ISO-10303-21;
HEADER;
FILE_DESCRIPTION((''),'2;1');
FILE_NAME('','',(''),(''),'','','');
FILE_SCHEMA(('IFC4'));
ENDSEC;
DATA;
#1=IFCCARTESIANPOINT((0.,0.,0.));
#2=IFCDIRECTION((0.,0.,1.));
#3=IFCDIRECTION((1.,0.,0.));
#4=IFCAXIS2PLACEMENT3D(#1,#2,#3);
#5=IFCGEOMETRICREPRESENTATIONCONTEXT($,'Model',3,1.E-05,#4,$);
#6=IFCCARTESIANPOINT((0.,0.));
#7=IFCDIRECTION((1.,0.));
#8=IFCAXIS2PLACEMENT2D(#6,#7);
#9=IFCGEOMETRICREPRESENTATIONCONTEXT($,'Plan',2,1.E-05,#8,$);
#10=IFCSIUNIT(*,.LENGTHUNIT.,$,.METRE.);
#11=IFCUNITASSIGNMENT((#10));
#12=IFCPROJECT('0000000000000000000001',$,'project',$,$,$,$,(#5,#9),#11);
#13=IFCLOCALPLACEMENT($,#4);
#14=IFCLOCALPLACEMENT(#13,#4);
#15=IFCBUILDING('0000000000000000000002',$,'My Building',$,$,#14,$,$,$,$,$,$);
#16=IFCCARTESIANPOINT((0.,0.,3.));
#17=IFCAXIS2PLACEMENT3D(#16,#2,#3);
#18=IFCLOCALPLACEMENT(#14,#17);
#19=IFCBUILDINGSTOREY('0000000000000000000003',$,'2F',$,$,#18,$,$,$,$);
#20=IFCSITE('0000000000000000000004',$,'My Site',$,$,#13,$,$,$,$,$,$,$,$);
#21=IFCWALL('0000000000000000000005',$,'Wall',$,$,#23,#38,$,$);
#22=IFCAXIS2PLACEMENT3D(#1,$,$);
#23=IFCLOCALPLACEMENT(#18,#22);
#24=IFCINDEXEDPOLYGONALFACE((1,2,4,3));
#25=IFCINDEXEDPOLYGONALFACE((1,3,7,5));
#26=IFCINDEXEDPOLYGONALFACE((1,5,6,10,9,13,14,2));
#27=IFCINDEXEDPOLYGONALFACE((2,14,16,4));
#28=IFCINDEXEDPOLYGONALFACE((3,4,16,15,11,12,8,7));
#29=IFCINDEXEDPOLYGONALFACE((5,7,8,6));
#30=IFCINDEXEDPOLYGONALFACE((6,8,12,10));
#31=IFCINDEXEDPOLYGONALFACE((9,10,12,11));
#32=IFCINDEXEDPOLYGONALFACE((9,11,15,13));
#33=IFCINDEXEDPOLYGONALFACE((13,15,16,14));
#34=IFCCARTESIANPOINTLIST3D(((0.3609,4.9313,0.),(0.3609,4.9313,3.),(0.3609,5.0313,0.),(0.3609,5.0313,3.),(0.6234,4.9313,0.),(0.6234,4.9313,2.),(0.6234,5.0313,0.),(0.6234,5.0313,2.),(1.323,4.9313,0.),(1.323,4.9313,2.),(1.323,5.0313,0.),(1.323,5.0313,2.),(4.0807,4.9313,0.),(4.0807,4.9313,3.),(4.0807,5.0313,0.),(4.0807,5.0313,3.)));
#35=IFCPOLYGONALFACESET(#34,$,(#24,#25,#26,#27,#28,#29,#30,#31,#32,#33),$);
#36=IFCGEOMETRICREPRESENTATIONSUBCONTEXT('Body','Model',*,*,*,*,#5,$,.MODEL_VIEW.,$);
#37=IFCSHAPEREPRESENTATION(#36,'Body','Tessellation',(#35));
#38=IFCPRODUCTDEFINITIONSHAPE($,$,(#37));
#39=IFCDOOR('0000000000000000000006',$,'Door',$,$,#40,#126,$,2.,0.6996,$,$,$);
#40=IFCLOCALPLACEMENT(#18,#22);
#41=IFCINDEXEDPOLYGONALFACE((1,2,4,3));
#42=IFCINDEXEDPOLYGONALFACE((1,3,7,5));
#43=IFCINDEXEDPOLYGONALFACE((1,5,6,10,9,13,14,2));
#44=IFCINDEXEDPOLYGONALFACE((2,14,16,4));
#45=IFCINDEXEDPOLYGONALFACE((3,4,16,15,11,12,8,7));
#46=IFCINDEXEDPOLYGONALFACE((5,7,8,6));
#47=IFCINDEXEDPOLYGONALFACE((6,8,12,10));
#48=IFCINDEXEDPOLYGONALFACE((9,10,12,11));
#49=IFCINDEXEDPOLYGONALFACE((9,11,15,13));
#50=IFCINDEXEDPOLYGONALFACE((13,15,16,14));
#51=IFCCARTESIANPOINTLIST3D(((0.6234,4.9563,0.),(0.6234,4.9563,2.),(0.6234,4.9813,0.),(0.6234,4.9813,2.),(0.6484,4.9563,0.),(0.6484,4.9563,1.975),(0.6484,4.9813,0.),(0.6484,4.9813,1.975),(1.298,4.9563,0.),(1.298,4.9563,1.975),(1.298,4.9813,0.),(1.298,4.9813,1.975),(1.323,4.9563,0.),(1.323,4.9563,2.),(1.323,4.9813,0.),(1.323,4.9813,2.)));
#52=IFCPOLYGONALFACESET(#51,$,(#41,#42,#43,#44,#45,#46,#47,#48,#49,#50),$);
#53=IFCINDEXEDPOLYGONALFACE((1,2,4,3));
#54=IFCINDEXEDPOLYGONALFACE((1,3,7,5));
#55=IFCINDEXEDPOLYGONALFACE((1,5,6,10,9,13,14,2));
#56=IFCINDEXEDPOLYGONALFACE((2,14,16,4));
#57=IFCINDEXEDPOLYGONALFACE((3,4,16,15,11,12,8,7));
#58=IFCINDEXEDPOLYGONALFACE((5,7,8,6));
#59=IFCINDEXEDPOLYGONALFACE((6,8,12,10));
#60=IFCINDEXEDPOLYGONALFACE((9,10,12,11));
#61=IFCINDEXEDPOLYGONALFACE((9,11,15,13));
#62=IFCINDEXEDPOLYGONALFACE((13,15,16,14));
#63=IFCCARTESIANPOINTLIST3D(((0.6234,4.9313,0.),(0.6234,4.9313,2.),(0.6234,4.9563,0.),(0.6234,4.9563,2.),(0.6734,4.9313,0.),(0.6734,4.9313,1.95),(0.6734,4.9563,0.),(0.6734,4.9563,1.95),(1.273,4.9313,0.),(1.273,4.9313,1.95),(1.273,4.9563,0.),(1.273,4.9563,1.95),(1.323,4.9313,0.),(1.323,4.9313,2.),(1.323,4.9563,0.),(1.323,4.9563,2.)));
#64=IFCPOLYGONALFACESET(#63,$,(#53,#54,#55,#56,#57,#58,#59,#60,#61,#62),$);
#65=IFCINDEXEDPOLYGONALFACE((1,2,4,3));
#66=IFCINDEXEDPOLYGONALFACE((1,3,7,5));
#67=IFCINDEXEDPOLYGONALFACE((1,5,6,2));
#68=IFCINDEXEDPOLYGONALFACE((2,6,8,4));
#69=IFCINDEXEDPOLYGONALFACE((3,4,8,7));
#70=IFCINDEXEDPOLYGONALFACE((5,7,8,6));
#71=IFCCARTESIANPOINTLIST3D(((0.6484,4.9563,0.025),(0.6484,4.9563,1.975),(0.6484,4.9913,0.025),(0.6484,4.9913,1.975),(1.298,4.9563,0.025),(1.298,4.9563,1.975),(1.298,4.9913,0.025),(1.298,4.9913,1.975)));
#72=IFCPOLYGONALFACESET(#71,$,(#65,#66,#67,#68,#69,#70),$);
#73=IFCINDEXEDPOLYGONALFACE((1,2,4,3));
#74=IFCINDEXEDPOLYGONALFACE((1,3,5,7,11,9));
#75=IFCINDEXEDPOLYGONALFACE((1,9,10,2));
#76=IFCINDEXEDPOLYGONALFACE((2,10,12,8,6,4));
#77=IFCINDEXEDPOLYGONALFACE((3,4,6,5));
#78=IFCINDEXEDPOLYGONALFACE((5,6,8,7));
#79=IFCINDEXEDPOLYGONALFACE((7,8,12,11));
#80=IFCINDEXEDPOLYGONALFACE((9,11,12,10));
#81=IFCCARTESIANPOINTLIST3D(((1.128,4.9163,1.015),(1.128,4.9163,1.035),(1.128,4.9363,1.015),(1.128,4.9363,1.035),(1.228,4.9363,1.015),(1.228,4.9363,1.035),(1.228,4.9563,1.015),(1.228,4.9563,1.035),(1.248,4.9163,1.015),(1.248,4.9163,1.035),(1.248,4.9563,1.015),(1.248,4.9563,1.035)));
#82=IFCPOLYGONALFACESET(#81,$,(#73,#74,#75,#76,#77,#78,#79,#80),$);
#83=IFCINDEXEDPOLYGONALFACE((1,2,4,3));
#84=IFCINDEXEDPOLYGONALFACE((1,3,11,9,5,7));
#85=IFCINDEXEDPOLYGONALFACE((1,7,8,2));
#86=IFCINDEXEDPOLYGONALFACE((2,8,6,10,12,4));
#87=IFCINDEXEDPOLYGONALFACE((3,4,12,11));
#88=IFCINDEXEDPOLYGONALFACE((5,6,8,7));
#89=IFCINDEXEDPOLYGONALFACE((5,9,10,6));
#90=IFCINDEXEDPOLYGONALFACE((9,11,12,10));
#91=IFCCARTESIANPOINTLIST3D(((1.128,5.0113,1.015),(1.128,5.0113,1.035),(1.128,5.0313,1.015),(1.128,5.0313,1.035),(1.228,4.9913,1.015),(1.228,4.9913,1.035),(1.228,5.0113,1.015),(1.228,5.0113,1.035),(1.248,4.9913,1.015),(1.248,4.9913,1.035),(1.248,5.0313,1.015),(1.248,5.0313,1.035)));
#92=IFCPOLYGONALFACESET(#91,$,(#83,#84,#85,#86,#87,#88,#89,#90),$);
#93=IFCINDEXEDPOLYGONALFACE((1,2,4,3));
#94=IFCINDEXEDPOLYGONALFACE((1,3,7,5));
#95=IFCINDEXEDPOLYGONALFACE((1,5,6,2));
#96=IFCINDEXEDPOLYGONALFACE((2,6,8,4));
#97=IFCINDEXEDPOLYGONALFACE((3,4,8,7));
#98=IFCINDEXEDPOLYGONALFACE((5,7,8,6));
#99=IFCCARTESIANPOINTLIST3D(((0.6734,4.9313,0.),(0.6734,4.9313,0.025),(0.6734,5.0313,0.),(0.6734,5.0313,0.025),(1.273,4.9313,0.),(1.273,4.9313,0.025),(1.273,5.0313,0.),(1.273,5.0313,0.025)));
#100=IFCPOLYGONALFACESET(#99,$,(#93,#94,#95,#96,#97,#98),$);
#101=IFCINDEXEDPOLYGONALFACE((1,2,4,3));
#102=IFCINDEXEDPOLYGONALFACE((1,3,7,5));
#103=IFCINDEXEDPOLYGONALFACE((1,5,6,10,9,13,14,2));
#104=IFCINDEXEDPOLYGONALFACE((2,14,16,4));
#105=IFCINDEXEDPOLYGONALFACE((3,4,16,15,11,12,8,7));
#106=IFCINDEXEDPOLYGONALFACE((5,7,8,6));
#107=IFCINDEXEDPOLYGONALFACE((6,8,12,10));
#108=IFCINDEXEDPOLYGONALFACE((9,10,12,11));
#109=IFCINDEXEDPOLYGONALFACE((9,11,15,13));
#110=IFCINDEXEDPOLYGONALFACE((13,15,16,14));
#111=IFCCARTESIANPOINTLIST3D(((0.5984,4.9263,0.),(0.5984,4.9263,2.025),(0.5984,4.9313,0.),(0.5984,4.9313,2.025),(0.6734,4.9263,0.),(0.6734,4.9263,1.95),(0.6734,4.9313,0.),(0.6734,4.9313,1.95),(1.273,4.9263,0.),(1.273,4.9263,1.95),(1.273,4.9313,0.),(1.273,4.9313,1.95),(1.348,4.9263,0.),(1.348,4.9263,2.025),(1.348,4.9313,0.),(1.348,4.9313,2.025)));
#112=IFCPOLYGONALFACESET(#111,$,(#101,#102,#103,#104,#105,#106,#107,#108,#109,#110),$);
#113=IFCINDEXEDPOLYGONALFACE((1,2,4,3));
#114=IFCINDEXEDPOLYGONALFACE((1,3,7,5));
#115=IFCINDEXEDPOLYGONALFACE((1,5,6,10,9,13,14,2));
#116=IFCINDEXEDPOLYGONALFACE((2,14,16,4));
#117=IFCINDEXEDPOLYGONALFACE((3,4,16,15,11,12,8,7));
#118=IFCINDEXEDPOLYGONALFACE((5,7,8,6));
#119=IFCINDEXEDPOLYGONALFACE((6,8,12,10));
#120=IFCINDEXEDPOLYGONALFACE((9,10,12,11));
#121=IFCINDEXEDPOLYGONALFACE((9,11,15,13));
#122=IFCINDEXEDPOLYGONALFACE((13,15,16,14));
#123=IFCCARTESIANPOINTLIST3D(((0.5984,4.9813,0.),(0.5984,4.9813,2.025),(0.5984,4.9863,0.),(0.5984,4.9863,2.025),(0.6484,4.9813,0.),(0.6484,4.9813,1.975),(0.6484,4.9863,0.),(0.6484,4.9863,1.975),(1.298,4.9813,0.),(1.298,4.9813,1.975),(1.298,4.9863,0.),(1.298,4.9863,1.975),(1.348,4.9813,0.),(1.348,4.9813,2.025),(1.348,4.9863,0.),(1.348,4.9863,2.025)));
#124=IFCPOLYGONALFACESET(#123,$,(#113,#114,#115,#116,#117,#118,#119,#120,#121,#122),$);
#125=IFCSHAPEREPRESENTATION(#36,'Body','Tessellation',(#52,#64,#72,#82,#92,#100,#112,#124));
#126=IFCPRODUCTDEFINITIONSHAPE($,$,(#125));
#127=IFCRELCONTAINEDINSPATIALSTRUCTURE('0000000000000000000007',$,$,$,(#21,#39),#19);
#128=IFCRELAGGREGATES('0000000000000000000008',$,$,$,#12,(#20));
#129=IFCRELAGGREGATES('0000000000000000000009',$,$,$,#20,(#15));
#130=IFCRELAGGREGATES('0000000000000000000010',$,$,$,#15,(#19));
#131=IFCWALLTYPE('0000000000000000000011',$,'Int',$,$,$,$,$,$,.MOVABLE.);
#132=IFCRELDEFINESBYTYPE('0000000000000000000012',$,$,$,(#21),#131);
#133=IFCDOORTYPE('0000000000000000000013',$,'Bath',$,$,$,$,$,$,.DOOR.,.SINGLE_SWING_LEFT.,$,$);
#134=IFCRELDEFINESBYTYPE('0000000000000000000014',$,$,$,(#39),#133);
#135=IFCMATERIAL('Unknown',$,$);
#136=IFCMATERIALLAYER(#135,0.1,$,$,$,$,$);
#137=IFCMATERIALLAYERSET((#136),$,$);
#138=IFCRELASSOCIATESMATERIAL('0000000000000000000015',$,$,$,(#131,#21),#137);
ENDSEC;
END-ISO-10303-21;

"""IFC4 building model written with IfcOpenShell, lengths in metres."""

from ifc_helpers import new_model, entity, si_unit, frame, origin_with_axes, origin_2d_with_axis, place, context, subcontext, project, spatial, line, indexed_curve, outline, extrude, shape, source, transform, mapped, material, layer, layer_set, layer_usage, type_object, type_shapes, element, fill, save


model = new_model("IFC4")

# Units and contexts
model_context = context("Model", 3, precision=1e-05, world=origin_with_axes())
plan_context = context("Plan", 2, precision=1e-05, world=origin_2d_with_axis())
body_context_1 = subcontext(model_context, "Body", "Model", "MODEL_VIEW")
body_context_2 = subcontext(plan_context, "Body", "Plan", "PLAN_VIEW")
ifc_project = project(units=[si_unit("LENGTHUNIT", "METRE")], contexts=[model_context, plan_context])

# Site, building, storey
site_placement = place(None, origin_with_axes())
site = spatial("IfcSite", under=ifc_project, at=site_placement, Name="My Site")
building_placement = place(site_placement, origin_with_axes())
building = spatial("IfcBuilding", under=site, at=building_placement, Name="My Building")
storey_placement = place(building_placement, frame((0.0, 0.0, 3.0), z_axis=(0.0, 0.0, 1.0), x_axis=(1.0, 0.0, 0.0)))
storey = spatial("IfcBuildingStorey", under=building, at=storey_placement, Name="2F")

# Shared definitions
ifc_material = material(Name="Unknown")

# Shared definitions
ifc_layer_1 = layer(ifc_material, 0.1)
ifc_layer_set_1 = layer_set([ifc_layer_1])
wall_type_1 = type_object("IfcWallType", Name="Int", PredefinedType="MOVABLE", material=ifc_layer_set_1)

# Wall, opening, door
ifc_layer_usage_1 = layer_usage(ifc_layer_set_1, "AXIS2", "POSITIVE", 0.0)
wall_1_placement = place(storey_placement, frame((4.0807, 5.0313, 0.0), z_axis=(0.0, 0.0, 1.0), x_axis=(-1.0, 0.0, 0.0)))
wall_1 = element("IfcWall", 1, at=wall_1_placement, inside=storey, type_object=wall_type_1, material=ifc_layer_usage_1, Name="Wall", context=body_context_1, shape_type="SweptSolid", body=[
    extrude(outline(indexed_curve([(0.0, 0.0), (0.0, 0.1), (3.7198, 0.1), (3.7198, 0.0)], segments=[line(1, 2, 3, 4, 1)])), origin_with_axes(), (0.0, 0.0, 1.0), 3.0),
])
shared_shape_1 = source(origin_with_axes(), body_context_1, "Body", "SweptSolid", [
    extrude(outline(indexed_curve([(0.0, 0.0), (0.6996, 0.0), (0.6996, 2.0), (0.0, 2.0)], segments=[line(1, 2, 3, 4, 1)])), frame((0.0, -0.6, 0.0), z_axis=(0.0, -1.0, 0.0), x_axis=(1.0, 0.0, 0.0)), (0.0, 0.0, -1.0), 1.2),
])
opening_1_placement = place(wall_1_placement, frame((3.4573, 0.1, 0.0), z_axis=(0.0, 0.0, 1.0), x_axis=(-1.0, 0.0, 0.0)))
opening_1 = element("IfcOpeningElement", 2, at=opening_1_placement, cuts=wall_1, PredefinedType="OPENING", context=body_context_1, shape_type="MappedRepresentation", body=[
    mapped(shared_shape_1, transform((0.0, 0.0, 0.0), x_axis=(1.0, 0.0, 0.0), y_axis=(0.0, 1.0, 0.0), z_axis=(0.0, 0.0, 1.0), scale=1.0)),
])
door_type_1 = type_object("IfcDoorType", Name="Bath", OperationType="SINGLE_SWING_LEFT", PredefinedType="DOOR")
shared_shape_2 = source(origin_with_axes(), body_context_1, "Body", "SweptSolid", [
    extrude(outline(indexed_curve([(0.0, 0.0), (0.0, 2.0), (0.6996, 2.0), (0.6996, 0.0), (0.6746, 0.0), (0.6746, 1.975), (0.025, 1.975), (0.025, 0.0)], segments=[line(1, 2, 3, 4, 5, 6, 7, 8, 1)])), frame((0.0, 0.025, 0.0), z_axis=(0.0, -1.0, 0.0), x_axis=(1.0, 0.0, 0.0)), (0.0, 0.0, -1.0), 0.025),
    extrude(outline(indexed_curve([(0.0, 0.0), (0.0, 2.0), (0.6996, 2.0), (0.6996, 0.0), (0.6496, 0.0), (0.6496, 1.95), (0.05, 1.95), (0.05, 0.0)], segments=[line(1, 2, 3, 4, 5, 6, 7, 8, 1)])), frame((0.0, 0.0, 0.0), z_axis=(0.0, -1.0, 0.0), x_axis=(1.0, 0.0, 0.0)), (0.0, 0.0, -1.0), 0.025),
    extrude(outline(indexed_curve([(0.0, 0.0), (0.6496, 0.0), (0.6496, 0.035), (0.0, 0.035)], segments=[line(1, 2, 3, 4, 1)])), frame((0.025, 0.025, 0.025), z_axis=(0.0, 0.0, 1.0), x_axis=(1.0, 0.0, 0.0)), (0.0, 0.0, 1.0), 1.95),
    extrude(outline(indexed_curve([(0.0, 0.0), (0.0, -0.04), (-0.12, -0.04), (-0.12, -0.02), (-0.02, -0.02), (-0.02, 0.0)], segments=[line(1, 2, 3, 4, 5, 6, 1)])), frame((0.6246, 0.025, 1.015), z_axis=(0.0, 0.0, 1.0), x_axis=(1.0, 0.0, 0.0)), (0.0, 0.0, 1.0), 0.02),
    extrude(outline(indexed_curve([(0.0, 0.0), (0.0, 0.04), (-0.12, 0.04), (-0.12, 0.02), (-0.02, 0.02), (-0.02, 0.0)], segments=[line(1, 2, 3, 4, 5, 6, 1)])), frame((0.6246, 0.06, 1.015), z_axis=(0.0, 0.0, 1.0), x_axis=(1.0, 0.0, 0.0)), (0.0, 0.0, 1.0), 0.02),
    extrude(outline(indexed_curve([(0.0, 0.0), (0.5996, 0.0), (0.5996, 0.1), (0.0, 0.1)], segments=[line(1, 2, 3, 4, 1)])), frame((0.05, 0.0, 0.0), z_axis=(0.0, 0.0, 1.0), x_axis=(1.0, 0.0, 0.0)), (0.0, 0.0, 1.0), 0.025),
    extrude(outline(indexed_curve([(0.0, 0.0), (0.0, 2.025), (0.7496, 2.025), (0.7496, 0.0), (0.6746, 0.0), (0.6746, 1.95), (0.075, 1.95), (0.075, 0.0)], segments=[line(1, 2, 3, 4, 5, 6, 7, 8, 1)])), frame((-0.025, -0.005, 0.0), z_axis=(0.0, -1.0, 0.0), x_axis=(1.0, 0.0, 0.0)), (0.0, 0.0, -1.0), 0.005),
    extrude(outline(indexed_curve([(0.0, 0.0), (0.0, 2.025), (0.7496, 2.025), (0.7496, 0.0), (0.6996, 0.0), (0.6996, 1.975), (0.05, 1.975), (0.05, 0.0)], segments=[line(1, 2, 3, 4, 5, 6, 7, 8, 1)])), frame((-0.025, 0.05, 0.0), z_axis=(0.0, -1.0, 0.0), x_axis=(1.0, 0.0, 0.0)), (0.0, 0.0, -1.0), 0.005),
])
shared_shape_3 = source(origin_with_axes(), body_context_2, "Body", "Curve2D", [
    entity("IfcIndexedPolyCurve", entity("IfcCartesianPointList2D", [[0.0, 0.0], [0.0, 0.05], [0.025, 0.05], [0.025, 0.025], [0.05, 0.025], [0.05, 0.0]]), [entity("IfcLineIndex", [1, 2, 3, 4, 5, 6, 1])]),
    entity("IfcIndexedPolyCurve", entity("IfcCartesianPointList2D", [[0.6996, 0.0], [0.6996, 0.05], [0.6746, 0.05], [0.6746, 0.025], [0.6496, 0.025], [0.6496, 0.0]]), [entity("IfcLineIndex", [1, 2, 3, 4, 5, 6, 1])]),
    entity("IfcTrimmedCurve", entity("IfcEllipse", entity("IfcAxis2Placement2D", entity("IfcCartesianPoint", [0.06, 0.05]), entity("IfcDirection", [1.0, 0.0])), 0.6146, 0.6496), [entity("IfcCartesianPoint", [0.6746, 0.05])], [entity("IfcCartesianPoint", [0.06, 0.6996])], True, "CARTESIAN"),
    entity("IfcIndexedPolyCurve", entity("IfcCartesianPointList2D", [[0.025, 0.05], [0.06, 0.05], [0.06, 0.6996], [0.025, 0.6996]]), [entity("IfcLineIndex", [1, 2, 3, 4, 1])]),
])
type_shapes(door_type_1, [shared_shape_2, shared_shape_3])
door_1_placement = place(opening_1_placement, frame((0.0, 0.0, 0.0), z_axis=(0.0, 0.0, 1.0), x_axis=(1.0, 0.0, 0.0)))
door_1 = element("IfcDoor", 3, at=door_1_placement, inside=storey, type_object=door_type_1, Name="Door", OverallHeight=2.0, OverallWidth=0.6996, shapes=[
    shape(body_context_1, "Body", "MappedRepresentation", [mapped(shared_shape_2, transform((0.0, 0.0, 0.0), x_axis=(1.0, 0.0, 0.0), y_axis=(0.0, 1.0, 0.0), z_axis=(0.0, 0.0, 1.0), scale=1.0))]),
    shape(body_context_2, "Body", "MappedRepresentation", [mapped(shared_shape_3, transform((0.0, 0.0, 0.0), x_axis=(1.0, 0.0, 0.0), y_axis=(0.0, 1.0, 0.0), z_axis=(0.0, 0.0, 1.0), scale=1.0))]),
])
fill(opening_1, door_1)

save(model, "model.ifc")
